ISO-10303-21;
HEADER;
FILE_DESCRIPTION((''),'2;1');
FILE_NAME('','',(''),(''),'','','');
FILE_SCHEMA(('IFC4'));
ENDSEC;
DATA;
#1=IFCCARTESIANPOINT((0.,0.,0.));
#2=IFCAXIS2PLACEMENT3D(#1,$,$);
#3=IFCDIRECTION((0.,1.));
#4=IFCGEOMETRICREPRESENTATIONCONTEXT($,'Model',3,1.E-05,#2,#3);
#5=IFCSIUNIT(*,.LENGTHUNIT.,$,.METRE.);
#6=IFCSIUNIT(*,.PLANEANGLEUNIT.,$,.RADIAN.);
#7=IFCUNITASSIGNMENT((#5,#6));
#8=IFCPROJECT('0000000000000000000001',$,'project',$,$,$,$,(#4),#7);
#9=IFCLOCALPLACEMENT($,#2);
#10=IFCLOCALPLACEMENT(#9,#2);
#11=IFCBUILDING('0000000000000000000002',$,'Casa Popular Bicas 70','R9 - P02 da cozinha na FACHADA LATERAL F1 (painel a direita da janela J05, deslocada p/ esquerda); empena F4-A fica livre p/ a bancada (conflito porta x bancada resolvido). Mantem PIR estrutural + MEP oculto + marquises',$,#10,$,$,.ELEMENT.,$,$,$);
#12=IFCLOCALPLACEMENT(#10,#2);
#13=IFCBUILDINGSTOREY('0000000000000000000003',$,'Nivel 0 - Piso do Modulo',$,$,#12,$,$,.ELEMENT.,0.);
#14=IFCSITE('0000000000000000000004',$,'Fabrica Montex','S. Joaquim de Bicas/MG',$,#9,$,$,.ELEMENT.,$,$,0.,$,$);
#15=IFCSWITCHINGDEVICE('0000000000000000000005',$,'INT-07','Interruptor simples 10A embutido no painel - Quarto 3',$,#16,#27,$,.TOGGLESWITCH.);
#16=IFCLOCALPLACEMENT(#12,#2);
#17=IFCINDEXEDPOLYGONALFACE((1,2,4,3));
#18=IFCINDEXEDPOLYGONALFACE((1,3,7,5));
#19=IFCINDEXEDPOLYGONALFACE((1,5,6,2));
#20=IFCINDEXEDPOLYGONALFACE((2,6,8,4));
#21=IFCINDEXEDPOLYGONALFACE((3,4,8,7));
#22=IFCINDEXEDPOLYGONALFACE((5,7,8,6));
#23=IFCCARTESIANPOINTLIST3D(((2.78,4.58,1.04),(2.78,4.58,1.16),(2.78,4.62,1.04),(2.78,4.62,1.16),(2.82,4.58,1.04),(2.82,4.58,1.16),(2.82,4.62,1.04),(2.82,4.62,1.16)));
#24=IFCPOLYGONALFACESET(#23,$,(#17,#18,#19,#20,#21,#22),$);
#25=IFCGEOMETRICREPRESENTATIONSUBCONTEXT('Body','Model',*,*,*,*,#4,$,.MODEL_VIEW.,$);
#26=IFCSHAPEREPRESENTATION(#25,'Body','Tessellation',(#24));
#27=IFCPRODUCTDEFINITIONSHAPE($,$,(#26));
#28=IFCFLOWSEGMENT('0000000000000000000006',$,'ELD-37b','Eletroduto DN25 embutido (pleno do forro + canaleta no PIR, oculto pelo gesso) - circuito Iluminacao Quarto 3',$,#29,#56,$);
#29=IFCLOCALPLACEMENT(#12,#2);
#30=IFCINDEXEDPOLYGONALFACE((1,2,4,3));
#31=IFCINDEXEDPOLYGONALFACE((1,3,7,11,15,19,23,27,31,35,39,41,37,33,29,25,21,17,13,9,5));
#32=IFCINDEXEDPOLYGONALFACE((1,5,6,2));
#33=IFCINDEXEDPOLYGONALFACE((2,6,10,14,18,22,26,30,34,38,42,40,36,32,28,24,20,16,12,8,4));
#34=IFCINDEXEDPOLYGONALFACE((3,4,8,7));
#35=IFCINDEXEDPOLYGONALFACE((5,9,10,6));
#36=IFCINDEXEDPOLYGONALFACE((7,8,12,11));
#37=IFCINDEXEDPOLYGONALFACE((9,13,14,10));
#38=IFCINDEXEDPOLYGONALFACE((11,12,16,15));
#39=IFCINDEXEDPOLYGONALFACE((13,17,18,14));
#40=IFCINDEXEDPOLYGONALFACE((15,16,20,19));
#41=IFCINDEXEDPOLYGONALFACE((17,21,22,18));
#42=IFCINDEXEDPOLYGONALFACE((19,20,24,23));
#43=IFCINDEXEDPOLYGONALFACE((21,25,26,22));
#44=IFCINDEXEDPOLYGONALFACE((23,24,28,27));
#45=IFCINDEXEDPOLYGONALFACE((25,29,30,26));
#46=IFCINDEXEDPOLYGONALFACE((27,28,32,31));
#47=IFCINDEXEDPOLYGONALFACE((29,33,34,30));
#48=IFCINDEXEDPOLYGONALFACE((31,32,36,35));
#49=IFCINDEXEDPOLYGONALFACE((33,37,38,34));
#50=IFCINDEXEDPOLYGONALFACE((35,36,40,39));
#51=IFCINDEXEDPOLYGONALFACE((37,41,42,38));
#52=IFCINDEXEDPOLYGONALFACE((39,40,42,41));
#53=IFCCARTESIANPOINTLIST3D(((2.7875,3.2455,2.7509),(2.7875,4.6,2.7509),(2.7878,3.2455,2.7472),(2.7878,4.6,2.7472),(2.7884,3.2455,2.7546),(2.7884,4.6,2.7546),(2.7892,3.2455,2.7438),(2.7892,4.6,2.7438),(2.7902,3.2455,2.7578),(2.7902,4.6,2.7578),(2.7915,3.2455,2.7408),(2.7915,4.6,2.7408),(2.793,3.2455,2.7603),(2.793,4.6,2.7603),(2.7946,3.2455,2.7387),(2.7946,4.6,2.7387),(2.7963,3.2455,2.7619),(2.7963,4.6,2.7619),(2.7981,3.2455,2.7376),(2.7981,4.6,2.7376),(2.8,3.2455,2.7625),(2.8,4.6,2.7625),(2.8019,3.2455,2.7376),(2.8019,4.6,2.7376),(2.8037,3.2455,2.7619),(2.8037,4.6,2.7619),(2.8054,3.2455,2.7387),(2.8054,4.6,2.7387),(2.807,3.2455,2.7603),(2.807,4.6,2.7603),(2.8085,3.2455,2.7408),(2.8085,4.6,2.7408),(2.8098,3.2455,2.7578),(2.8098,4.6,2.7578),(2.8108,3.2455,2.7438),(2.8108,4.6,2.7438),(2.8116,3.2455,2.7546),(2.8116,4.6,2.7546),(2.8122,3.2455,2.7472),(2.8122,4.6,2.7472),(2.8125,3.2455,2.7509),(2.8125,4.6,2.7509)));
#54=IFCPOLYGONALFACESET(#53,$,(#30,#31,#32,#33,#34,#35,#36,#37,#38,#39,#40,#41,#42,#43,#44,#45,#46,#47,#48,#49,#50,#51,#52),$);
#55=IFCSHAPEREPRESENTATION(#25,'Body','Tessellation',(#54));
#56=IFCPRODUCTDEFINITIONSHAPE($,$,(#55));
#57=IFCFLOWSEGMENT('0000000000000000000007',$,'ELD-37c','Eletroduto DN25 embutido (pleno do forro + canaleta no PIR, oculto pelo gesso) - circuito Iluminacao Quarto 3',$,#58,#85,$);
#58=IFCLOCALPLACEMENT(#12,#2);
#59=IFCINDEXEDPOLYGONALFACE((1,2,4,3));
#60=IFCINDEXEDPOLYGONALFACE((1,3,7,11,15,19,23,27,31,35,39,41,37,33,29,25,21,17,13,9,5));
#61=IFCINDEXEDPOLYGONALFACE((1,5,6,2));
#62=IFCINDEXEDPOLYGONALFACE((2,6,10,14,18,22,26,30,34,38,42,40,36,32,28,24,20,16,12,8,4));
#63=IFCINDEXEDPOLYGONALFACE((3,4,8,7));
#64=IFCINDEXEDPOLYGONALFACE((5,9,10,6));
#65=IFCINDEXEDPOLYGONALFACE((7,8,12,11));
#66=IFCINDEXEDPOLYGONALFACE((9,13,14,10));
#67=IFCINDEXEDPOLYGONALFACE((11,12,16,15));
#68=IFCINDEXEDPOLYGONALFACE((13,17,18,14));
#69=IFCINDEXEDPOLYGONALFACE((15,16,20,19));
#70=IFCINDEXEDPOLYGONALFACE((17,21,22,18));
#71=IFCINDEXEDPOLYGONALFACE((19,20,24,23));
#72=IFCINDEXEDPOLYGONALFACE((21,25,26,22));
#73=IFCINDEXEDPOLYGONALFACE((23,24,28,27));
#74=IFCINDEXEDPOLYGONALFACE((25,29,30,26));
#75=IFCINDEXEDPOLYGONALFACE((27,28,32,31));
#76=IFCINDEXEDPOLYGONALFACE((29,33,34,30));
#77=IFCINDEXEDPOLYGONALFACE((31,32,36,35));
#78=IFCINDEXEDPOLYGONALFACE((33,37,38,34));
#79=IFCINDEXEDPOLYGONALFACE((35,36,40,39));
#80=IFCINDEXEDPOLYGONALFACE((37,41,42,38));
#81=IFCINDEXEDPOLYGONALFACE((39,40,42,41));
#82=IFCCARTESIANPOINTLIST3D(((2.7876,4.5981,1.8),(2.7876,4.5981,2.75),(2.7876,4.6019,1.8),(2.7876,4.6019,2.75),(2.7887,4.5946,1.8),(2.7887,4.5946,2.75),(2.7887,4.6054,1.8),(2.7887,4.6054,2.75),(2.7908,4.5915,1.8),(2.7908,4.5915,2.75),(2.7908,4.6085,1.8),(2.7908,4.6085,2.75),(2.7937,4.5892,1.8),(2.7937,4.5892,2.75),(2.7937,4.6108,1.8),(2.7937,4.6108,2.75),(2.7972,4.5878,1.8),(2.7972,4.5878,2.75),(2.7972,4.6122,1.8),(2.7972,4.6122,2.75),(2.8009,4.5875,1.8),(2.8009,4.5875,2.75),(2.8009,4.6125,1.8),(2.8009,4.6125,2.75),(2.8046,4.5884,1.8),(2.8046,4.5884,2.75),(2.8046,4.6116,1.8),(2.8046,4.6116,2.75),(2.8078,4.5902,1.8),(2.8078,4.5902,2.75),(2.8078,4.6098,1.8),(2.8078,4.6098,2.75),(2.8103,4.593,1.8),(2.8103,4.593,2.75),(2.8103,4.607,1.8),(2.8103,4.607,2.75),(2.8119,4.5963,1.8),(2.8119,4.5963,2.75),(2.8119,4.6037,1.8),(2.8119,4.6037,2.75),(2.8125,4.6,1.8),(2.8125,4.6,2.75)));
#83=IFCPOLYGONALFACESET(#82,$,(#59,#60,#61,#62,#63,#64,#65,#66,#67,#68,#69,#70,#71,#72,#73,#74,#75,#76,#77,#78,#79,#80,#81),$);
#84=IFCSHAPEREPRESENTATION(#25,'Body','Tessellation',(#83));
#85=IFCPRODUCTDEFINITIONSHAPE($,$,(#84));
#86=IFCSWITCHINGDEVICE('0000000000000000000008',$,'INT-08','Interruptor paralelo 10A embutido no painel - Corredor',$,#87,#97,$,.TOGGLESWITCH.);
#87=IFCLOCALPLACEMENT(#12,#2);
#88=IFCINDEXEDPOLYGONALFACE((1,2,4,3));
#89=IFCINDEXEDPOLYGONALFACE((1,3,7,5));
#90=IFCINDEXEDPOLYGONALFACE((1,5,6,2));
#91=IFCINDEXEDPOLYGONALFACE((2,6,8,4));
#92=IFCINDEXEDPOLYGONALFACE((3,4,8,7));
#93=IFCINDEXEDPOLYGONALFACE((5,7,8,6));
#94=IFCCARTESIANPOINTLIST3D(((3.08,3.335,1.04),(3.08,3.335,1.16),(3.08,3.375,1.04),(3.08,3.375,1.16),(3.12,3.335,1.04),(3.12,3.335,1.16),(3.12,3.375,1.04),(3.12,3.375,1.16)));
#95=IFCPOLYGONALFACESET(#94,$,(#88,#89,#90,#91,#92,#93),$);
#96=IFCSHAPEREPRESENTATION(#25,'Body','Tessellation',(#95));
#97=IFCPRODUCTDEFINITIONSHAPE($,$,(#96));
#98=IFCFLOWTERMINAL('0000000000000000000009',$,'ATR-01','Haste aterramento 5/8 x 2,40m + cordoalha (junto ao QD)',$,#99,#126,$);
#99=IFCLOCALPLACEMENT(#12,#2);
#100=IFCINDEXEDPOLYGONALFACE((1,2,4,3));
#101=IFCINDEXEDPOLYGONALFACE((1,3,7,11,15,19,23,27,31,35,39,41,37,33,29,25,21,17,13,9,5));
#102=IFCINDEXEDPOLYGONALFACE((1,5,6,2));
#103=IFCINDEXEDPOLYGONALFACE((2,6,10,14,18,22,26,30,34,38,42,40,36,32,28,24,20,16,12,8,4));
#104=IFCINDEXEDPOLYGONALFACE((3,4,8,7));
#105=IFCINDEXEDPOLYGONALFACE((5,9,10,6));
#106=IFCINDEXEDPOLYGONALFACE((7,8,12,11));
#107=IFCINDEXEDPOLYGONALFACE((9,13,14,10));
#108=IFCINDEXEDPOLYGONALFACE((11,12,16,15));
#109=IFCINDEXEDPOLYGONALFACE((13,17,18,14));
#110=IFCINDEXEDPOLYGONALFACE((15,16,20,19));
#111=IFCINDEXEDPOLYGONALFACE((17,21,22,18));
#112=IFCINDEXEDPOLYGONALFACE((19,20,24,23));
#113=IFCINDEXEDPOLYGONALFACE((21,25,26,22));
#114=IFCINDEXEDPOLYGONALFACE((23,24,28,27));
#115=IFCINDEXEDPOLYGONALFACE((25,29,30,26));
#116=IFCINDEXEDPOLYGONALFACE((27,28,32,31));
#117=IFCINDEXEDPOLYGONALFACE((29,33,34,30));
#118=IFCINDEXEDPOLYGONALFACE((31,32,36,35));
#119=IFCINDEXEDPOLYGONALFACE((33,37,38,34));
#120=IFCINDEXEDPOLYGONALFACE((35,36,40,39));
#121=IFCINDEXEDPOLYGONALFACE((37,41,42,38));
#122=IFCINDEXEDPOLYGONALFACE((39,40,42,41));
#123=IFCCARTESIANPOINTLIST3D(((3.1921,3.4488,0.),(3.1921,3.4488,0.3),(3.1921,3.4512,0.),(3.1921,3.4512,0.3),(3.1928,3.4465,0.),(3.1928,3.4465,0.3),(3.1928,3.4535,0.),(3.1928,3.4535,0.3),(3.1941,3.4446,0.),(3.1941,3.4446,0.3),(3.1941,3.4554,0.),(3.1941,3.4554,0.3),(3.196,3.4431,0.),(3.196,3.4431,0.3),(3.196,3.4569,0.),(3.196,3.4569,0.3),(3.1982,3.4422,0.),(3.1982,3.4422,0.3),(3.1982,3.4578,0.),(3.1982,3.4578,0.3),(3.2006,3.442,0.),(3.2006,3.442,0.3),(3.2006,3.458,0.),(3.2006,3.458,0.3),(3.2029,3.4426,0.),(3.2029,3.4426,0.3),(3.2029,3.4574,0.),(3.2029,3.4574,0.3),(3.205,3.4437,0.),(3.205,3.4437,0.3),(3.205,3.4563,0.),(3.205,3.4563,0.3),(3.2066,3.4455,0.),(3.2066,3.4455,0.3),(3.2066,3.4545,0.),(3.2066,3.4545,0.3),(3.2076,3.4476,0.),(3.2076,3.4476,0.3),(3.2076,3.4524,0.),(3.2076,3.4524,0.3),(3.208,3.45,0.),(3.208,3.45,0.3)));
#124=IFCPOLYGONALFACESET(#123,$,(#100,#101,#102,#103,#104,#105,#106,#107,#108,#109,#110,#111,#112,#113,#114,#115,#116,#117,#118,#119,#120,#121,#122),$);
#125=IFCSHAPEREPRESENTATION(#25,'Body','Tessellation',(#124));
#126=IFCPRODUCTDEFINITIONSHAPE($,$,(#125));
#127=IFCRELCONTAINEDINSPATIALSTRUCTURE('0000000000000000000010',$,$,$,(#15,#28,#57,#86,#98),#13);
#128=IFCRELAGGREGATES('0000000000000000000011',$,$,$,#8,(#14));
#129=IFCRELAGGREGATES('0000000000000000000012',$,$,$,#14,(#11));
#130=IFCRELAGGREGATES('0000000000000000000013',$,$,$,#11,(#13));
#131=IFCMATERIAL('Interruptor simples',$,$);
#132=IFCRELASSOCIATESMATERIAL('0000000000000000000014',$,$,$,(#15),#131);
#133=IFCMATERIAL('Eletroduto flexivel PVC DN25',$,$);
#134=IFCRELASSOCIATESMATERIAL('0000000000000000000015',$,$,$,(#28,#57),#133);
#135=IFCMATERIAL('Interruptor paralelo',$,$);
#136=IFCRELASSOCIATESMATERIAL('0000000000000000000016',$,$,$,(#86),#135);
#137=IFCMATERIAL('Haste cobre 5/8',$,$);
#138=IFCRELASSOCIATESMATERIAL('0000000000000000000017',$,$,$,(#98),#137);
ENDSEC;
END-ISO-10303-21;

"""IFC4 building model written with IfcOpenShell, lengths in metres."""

from ifc_helpers import new_model, si_unit, direction, frame, frame_2d, origin, origin_2d, place, context, subcontext, project, spatial, rectangle, circle, extrude, material, element, save


model = new_model("IFC4")

# Units and contexts
model_context = context("Model", 3, precision=1e-05, world=origin(), true_north=direction((0.0, 1.0)))
body_context = subcontext(model_context, "Body", "Model", "MODEL_VIEW")
ifc_project = project(units=[si_unit("LENGTHUNIT", "METRE"), si_unit("PLANEANGLEUNIT", "RADIAN")], contexts=[model_context])

# Site, building, storey
site_placement = place(None, origin())
site = spatial("IfcSite", under=ifc_project, at=site_placement, Name="Fabrica Montex", Description="S. Joaquim de Bicas/MG", CompositionType="ELEMENT", RefElevation=0.0)
building_placement = place(site_placement, origin())
building = spatial("IfcBuilding", under=site, at=building_placement, Name="Casa Popular Bicas 70", Description="R9 - P02 da cozinha na FACHADA LATERAL F1 (painel a direita da janela J05, deslocada p/ esquerda); empena F4-A fica livre p/ a bancada (conflito porta x bancada resolvido). Mantem PIR estrutural + MEP oculto + marquises", CompositionType="ELEMENT")
storey_placement = place(building_placement, origin())
storey = spatial("IfcBuildingStorey", under=building, at=storey_placement, Name="Nivel 0 - Piso do Modulo", CompositionType="ELEMENT", Elevation=0.0)

# Shared definitions
ifc_material_1 = material(Name="Eletroduto flexivel PVC DN25")

# Switching device
ifc_material_2 = material(Name="Interruptor simples")
switching_device_1_placement = place(storey_placement, frame((2.78, 4.58, 1.04)))
element("IfcSwitchingDevice", 1, at=switching_device_1_placement, inside=storey, material=ifc_material_2, Name="INT-07", Description="Interruptor simples 10A embutido no painel - Quarto 3", PredefinedType="TOGGLESWITCH", context=body_context, shape_type="SweptSolid", body=[
    extrude(rectangle(XDim=0.04, YDim=0.04, at=frame_2d((0.02, 0.02))), origin(), (0.0, 0.0, 1.0), 0.12),
])

# Flow segments
flow_segment_1_placement = place(storey_placement, frame((2.8, 3.2455, 2.75), z_axis=(0.0, 1.0, 0.0), x_axis=(0.0, 0.0, 1.0)))
element("IfcFlowSegment", 2, at=flow_segment_1_placement, inside=storey, material=ifc_material_1, Name="ELD-37b", Description="Eletroduto DN25 embutido (pleno do forro + canaleta no PIR, oculto pelo gesso) - circuito Iluminacao Quarto 3", context=body_context, shape_type="SweptSolid", body=[
    extrude(circle(Radius=0.0125, at=origin_2d()), origin(), (0.0, 0.0, 1.0), 1.3545),
])
flow_segment_2_placement = place(storey_placement, frame((2.8, 4.6, 2.75), z_axis=(0.0, 0.0, -1.0), x_axis=(1.0, 0.0, 0.0)))
element("IfcFlowSegment", 3, at=flow_segment_2_placement, inside=storey, material=ifc_material_1, Name="ELD-37c", Description="Eletroduto DN25 embutido (pleno do forro + canaleta no PIR, oculto pelo gesso) - circuito Iluminacao Quarto 3", context=body_context, shape_type="SweptSolid", body=[
    extrude(circle(Radius=0.0125, at=origin_2d()), origin(), (0.0, 0.0, 1.0), 0.95),
])

# Switching device
ifc_material_3 = material(Name="Interruptor paralelo")
switching_device_2_placement = place(storey_placement, frame((3.08, 3.335, 1.04)))
element("IfcSwitchingDevice", 4, at=switching_device_2_placement, inside=storey, material=ifc_material_3, Name="INT-08", Description="Interruptor paralelo 10A embutido no painel - Corredor", PredefinedType="TOGGLESWITCH", context=body_context, shape_type="SweptSolid", body=[
    extrude(rectangle(XDim=0.04, YDim=0.04, at=frame_2d((0.02, 0.02))), origin(), (0.0, 0.0, 1.0), 0.12),
])

# Flow terminal
ifc_material_4 = material(Name="Haste cobre 5/8")
flow_terminal_placement = place(storey_placement, frame((3.2, 3.45, 0.0)))
element("IfcFlowTerminal", 5, at=flow_terminal_placement, inside=storey, material=ifc_material_4, Name="ATR-01", Description="Haste aterramento 5/8 x 2,40m + cordoalha (junto ao QD)", context=body_context, shape_type="SweptSolid", body=[
    extrude(circle(Radius=0.008, at=origin_2d()), origin(), (0.0, 0.0, 1.0), 0.3),
])

save(model, "model.ifc")
